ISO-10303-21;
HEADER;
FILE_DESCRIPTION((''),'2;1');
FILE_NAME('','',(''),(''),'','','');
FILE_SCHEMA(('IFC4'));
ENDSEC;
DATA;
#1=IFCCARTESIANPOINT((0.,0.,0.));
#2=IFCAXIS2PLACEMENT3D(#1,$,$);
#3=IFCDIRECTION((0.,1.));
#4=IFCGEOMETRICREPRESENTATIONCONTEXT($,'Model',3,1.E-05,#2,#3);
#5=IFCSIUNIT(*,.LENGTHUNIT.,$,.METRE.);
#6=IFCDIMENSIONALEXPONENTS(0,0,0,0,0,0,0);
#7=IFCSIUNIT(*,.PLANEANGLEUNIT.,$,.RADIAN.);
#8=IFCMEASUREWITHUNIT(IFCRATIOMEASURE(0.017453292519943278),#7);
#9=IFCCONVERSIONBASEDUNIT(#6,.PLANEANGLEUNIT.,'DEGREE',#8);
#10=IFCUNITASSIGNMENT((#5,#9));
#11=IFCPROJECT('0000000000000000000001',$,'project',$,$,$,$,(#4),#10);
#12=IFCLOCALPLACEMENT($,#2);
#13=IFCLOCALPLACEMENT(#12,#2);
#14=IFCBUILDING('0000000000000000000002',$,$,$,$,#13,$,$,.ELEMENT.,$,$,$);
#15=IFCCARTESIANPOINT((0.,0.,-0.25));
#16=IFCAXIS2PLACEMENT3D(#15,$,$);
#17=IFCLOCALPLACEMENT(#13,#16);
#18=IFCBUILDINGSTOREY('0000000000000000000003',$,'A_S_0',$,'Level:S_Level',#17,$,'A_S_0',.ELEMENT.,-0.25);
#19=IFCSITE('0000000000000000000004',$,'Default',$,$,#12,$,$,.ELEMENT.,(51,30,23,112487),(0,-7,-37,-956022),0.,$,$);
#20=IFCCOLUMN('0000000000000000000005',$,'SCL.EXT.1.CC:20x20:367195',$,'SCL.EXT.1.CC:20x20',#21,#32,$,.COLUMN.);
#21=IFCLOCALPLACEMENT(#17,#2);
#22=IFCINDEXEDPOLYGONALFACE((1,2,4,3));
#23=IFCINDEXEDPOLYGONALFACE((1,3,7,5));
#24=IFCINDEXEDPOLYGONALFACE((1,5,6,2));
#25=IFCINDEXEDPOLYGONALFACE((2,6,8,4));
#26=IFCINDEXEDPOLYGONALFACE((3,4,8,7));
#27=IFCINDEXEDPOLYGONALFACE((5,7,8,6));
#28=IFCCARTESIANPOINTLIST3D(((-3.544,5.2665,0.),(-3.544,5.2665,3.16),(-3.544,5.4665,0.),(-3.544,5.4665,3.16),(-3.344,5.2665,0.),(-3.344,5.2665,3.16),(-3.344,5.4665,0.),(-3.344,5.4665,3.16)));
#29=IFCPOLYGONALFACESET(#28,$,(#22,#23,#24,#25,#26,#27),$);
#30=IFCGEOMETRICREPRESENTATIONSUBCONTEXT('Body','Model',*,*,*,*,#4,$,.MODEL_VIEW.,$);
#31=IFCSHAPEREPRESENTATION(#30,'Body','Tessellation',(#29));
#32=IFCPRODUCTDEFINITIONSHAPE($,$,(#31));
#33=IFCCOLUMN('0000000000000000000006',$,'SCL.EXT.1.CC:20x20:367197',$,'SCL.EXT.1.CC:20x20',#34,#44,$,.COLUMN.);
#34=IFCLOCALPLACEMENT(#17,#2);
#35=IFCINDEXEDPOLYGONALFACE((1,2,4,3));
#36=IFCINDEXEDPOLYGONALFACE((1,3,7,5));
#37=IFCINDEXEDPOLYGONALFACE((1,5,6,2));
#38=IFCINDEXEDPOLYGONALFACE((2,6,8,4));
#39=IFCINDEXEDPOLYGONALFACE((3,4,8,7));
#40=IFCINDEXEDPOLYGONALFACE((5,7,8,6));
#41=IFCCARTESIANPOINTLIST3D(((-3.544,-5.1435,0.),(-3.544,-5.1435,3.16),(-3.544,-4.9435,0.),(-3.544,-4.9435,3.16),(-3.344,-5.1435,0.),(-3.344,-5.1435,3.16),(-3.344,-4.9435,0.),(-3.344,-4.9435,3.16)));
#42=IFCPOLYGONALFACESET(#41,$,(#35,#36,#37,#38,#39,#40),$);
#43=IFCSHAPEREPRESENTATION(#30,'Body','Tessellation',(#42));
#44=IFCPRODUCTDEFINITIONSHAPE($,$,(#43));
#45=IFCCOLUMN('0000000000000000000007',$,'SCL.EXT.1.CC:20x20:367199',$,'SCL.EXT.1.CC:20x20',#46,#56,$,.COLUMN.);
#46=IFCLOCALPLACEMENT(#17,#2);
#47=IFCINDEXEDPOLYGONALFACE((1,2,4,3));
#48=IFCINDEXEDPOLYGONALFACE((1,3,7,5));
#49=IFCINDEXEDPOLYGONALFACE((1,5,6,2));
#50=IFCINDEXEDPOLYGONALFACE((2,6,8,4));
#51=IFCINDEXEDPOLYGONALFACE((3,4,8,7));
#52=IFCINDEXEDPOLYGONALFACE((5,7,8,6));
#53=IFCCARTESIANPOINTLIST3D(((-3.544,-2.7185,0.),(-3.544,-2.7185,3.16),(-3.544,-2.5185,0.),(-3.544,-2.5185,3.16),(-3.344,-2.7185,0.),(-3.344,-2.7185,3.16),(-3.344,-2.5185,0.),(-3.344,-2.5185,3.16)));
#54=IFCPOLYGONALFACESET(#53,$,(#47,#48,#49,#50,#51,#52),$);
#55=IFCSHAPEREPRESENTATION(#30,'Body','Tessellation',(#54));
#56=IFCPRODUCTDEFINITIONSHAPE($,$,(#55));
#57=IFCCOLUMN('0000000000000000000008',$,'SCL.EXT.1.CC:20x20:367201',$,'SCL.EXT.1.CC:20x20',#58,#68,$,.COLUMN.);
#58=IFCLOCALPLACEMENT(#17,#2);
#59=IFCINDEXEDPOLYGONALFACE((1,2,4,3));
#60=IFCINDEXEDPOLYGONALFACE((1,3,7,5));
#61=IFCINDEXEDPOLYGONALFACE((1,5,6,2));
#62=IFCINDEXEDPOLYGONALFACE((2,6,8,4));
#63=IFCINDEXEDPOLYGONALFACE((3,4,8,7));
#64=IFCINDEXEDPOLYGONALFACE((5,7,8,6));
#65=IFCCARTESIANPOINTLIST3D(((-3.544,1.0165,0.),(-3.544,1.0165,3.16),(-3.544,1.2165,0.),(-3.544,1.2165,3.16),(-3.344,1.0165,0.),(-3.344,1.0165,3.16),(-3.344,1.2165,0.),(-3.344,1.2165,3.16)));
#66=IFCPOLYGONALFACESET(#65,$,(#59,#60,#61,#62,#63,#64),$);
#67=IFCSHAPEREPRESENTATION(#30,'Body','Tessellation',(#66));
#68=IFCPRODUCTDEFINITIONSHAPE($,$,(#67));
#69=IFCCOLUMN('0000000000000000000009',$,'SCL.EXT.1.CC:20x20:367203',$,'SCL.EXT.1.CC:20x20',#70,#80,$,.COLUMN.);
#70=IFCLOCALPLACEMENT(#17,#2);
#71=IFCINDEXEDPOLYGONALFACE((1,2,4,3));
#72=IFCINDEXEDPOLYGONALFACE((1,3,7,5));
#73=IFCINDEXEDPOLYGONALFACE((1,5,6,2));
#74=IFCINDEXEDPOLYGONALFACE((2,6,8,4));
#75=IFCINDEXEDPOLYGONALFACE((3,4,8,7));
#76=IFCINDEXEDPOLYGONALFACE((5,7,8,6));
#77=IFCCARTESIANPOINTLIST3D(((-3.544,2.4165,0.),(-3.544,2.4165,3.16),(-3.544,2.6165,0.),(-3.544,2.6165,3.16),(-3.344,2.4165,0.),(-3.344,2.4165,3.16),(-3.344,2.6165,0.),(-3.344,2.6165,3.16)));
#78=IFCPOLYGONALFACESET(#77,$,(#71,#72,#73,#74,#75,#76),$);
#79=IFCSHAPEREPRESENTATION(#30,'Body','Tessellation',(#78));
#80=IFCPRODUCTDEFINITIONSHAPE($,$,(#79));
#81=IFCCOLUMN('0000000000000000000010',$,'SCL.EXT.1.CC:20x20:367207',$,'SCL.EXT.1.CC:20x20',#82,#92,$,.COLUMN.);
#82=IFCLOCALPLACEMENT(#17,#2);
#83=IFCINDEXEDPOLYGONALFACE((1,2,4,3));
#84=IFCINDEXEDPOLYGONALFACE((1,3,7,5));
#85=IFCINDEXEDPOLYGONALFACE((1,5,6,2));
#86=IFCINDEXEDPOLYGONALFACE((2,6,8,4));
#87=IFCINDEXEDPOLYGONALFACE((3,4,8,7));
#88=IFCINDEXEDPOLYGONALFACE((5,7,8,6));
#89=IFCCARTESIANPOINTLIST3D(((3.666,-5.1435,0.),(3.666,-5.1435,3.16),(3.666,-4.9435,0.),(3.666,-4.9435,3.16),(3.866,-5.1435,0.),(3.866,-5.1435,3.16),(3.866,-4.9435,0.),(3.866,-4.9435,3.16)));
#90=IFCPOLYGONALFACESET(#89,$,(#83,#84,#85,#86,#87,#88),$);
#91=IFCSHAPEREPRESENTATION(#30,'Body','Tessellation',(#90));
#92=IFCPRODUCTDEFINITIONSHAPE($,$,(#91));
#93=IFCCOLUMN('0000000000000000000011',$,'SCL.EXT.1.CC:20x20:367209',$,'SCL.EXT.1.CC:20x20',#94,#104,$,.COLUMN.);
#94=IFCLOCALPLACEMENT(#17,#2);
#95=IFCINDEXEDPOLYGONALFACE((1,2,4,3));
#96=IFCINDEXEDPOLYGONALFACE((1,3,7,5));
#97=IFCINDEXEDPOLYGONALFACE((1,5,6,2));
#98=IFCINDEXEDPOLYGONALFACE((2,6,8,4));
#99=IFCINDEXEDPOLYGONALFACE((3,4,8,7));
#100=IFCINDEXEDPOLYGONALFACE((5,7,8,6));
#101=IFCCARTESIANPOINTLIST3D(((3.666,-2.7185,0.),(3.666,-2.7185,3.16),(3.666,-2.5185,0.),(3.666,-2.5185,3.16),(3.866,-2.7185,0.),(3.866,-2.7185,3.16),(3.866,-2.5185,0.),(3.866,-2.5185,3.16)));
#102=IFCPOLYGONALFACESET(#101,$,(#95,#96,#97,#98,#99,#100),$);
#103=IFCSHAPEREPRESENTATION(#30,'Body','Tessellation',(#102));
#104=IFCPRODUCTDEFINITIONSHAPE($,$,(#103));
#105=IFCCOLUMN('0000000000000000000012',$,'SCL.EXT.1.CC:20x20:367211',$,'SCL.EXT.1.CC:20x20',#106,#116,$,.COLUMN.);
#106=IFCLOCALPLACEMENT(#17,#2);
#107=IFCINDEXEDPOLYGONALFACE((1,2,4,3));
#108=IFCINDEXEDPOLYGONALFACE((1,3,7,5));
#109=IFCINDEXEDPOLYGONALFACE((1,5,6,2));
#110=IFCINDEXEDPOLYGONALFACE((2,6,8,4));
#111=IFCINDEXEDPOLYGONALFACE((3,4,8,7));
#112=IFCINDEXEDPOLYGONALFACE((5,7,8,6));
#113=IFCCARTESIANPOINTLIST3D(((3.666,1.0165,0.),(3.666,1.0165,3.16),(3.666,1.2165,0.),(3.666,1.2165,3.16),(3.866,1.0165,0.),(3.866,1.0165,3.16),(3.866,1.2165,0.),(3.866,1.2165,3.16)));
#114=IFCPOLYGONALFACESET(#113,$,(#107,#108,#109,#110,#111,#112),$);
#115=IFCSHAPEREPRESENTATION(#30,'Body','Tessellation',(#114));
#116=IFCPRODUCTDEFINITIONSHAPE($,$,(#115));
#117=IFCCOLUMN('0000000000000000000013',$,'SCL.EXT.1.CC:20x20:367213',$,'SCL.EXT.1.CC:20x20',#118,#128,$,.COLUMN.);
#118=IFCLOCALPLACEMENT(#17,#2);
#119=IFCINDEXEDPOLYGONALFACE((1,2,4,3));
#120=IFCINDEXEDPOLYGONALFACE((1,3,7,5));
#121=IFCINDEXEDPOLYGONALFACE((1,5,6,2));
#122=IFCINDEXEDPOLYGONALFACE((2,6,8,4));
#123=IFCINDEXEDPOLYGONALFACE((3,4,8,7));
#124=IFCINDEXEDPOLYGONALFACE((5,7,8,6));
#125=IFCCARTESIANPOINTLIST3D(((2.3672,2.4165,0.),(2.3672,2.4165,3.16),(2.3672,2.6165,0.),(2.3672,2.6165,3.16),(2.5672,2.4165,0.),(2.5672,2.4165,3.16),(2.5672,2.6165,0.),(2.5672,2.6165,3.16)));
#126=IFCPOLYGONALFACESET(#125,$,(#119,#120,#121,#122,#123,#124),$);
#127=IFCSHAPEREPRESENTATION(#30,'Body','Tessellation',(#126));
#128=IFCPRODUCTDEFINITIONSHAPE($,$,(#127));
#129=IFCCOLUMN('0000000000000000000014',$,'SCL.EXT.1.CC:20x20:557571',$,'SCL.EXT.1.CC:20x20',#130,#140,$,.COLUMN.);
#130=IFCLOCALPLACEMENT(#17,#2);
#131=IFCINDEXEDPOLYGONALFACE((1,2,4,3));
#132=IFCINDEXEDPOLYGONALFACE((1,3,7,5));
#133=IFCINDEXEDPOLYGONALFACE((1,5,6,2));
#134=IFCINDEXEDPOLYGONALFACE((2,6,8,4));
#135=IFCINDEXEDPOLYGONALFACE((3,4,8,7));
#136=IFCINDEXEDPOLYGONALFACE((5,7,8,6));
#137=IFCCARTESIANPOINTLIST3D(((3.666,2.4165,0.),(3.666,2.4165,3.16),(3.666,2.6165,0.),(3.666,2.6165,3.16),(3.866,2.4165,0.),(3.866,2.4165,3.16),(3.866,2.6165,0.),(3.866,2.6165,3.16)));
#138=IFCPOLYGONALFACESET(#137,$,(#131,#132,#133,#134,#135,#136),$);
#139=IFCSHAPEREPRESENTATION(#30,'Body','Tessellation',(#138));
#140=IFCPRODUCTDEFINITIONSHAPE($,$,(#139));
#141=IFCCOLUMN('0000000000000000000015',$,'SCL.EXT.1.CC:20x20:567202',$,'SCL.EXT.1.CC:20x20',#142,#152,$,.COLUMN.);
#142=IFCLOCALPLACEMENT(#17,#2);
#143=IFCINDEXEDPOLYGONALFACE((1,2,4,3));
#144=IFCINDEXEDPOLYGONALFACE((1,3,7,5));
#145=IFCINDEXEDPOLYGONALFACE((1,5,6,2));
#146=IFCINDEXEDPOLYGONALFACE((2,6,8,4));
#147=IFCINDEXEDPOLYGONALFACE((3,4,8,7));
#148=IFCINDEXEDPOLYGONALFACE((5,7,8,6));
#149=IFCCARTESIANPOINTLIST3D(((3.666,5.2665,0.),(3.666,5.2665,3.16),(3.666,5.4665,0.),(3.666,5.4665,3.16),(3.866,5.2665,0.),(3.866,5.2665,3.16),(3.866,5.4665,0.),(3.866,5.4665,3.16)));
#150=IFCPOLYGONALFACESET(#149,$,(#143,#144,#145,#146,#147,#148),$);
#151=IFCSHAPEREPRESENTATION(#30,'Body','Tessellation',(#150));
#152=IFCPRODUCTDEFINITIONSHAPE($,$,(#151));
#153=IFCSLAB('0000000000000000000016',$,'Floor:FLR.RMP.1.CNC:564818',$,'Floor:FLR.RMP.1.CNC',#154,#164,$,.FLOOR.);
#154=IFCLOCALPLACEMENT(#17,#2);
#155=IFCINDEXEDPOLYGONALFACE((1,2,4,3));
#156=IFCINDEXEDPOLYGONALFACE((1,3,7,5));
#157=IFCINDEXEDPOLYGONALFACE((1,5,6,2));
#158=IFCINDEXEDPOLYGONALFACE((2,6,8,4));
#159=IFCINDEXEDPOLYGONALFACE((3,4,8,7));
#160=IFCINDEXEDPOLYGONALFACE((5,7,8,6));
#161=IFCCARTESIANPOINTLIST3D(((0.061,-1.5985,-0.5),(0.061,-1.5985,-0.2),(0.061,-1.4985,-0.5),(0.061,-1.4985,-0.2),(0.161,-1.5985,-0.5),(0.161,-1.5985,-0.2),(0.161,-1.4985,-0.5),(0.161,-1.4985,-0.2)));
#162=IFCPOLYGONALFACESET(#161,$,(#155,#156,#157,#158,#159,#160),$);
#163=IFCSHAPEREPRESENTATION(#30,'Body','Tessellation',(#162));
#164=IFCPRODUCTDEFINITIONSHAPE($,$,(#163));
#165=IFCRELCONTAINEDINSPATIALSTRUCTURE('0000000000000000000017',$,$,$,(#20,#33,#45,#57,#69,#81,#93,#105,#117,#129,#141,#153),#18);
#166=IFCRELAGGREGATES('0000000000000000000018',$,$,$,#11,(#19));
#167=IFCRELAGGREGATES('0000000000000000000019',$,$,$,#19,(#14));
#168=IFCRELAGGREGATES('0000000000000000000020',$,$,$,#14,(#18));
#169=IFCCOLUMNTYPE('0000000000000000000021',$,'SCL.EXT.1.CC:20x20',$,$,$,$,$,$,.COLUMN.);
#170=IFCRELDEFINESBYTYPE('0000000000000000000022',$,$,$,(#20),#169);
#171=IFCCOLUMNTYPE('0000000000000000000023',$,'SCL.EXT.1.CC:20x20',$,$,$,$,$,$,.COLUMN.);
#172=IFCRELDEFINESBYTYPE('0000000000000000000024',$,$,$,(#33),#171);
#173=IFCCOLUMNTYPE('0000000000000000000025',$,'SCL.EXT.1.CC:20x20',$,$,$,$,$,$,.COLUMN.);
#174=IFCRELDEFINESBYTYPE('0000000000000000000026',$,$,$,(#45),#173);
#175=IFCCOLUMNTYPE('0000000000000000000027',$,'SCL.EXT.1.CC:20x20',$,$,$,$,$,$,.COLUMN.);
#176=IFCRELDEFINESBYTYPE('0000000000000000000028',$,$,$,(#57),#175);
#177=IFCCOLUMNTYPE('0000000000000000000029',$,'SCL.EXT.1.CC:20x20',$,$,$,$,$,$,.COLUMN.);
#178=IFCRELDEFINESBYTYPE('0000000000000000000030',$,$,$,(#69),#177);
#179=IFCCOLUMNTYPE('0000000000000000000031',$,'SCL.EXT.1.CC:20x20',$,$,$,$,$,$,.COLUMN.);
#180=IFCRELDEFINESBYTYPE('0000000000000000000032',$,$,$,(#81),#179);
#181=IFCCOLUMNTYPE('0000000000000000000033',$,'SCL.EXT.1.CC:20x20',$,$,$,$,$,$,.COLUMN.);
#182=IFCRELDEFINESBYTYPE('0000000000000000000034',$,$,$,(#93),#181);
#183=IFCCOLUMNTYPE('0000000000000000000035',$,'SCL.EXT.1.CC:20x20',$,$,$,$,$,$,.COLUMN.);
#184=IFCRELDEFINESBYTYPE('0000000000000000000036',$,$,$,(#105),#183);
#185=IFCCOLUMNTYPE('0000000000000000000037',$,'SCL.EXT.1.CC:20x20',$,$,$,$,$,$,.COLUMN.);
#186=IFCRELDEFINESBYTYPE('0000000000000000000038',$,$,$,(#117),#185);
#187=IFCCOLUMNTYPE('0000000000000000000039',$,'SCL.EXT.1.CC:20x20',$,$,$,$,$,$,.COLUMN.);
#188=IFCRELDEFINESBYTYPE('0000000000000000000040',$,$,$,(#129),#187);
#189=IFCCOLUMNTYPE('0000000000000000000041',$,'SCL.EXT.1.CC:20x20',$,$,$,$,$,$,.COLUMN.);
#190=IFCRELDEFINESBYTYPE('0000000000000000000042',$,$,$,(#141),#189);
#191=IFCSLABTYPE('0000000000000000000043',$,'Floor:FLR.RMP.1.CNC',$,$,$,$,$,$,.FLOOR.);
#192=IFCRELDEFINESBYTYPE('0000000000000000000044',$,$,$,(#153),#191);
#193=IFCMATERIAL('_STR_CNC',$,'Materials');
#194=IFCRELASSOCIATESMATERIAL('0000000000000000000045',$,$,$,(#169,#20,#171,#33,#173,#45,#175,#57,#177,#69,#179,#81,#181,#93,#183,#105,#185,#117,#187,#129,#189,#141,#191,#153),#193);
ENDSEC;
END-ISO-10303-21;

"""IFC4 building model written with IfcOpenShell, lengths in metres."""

from ifc_helpers import new_model, entity, si_unit, converted_unit, direction, frame, origin, place, context, subcontext, project, spatial, indexed_curve, outline, extrude, source, transform, mapped, material, type_object, type_shapes, element, save


model = new_model("IFC4")

# Units and contexts
model_context = context("Model", 3, precision=1e-05, world=origin(), true_north=direction((0.0, 1.0)))
body_context = subcontext(model_context, "Body", "Model", "MODEL_VIEW")
ifc_project = project(units=[si_unit("LENGTHUNIT", "METRE"), converted_unit("PLANEANGLEUNIT", "DEGREE", entity("IfcRatioMeasure", 0.017453292519943278), si_unit("PLANEANGLEUNIT", "RADIAN"), dimensions=[0, 0, 0, 0, 0, 0, 0])], contexts=[model_context])

# Site, building, storey
site_placement = place(None, origin())
site = spatial("IfcSite", under=ifc_project, at=site_placement, Name="Default", CompositionType="ELEMENT", RefLatitude=(51, 30, 23, 112487), RefLongitude=(0, -7, -37, -956022), RefElevation=0.0)
building_placement = place(site_placement, origin())
building = spatial("IfcBuilding", under=site, at=building_placement, CompositionType="ELEMENT")
storey_placement = place(building_placement, frame((0.0, 0.0, -0.25)))
storey = spatial("IfcBuildingStorey", under=building, at=storey_placement, Name="A_S_0", ObjectType="Level:S_Level", LongName="A_S_0", CompositionType="ELEMENT", Elevation=-0.25)

# Columns
ifc_material_1 = material(Name="_STR_CNC", Category="Materials")
column_type_1 = type_object("IfcColumnType", Name="SCL.EXT.1.CC:20x20", PredefinedType="COLUMN", material=ifc_material_1)
shared_shape_1 = source(origin(), body_context, "Body", "SweptSolid", [
    extrude(outline(indexed_curve([(-0.1, -0.1), (0.1, -0.1), (0.1, 0.1), (-0.1, 0.1), (-0.1, -0.1)], self_intersect=False)), frame((-3.444, 5.3665, -0.25), z_axis=(0.0, 0.0, 1.0), x_axis=(0.0, -1.0, 0.0)), (0.0, 0.0, 1.0), 3.16),
])
type_shapes(column_type_1, [shared_shape_1])
column_1_placement = place(storey_placement, frame((0.0, 0.0, 0.25)))
element("IfcColumn", 1, at=column_1_placement, inside=storey, type_object=column_type_1, material=ifc_material_1, Name="SCL.EXT.1.CC:20x20:367195", ObjectType="SCL.EXT.1.CC:20x20", PredefinedType="COLUMN", context=body_context, shape_type="MappedRepresentation", body=[
    mapped(shared_shape_1, transform((0.0, 0.0, 0.0), scale=1.0)),
])
column_type_2 = type_object("IfcColumnType", Name="SCL.EXT.1.CC:20x20", PredefinedType="COLUMN", material=ifc_material_1)
shared_shape_2 = source(origin(), body_context, "Body", "SweptSolid", [
    extrude(outline(indexed_curve([(-0.1, -0.1), (0.1, -0.1), (0.1, 0.1), (-0.1, 0.1), (-0.1, -0.1)], self_intersect=False)), frame((-3.444, -5.0435, -0.25), z_axis=(0.0, 0.0, 1.0), x_axis=(0.0, -1.0, 0.0)), (0.0, 0.0, 1.0), 3.16),
])
type_shapes(column_type_2, [shared_shape_2])
column_2_placement = place(storey_placement, frame((0.0, 0.0, 0.25)))
element("IfcColumn", 2, at=column_2_placement, inside=storey, type_object=column_type_2, material=ifc_material_1, Name="SCL.EXT.1.CC:20x20:367197", ObjectType="SCL.EXT.1.CC:20x20", PredefinedType="COLUMN", context=body_context, shape_type="MappedRepresentation", body=[
    mapped(shared_shape_2, transform((0.0, 0.0, 0.0), scale=1.0)),
])
column_type_3 = type_object("IfcColumnType", Name="SCL.EXT.1.CC:20x20", PredefinedType="COLUMN", material=ifc_material_1)
shared_shape_3 = source(origin(), body_context, "Body", "SweptSolid", [
    extrude(outline(indexed_curve([(-0.1, -0.1), (0.1, -0.1), (0.1, 0.1), (-0.1, 0.1), (-0.1, -0.1)], self_intersect=False)), frame((-3.444, -2.6185, -0.25), z_axis=(0.0, 0.0, 1.0), x_axis=(0.0, -1.0, 0.0)), (0.0, 0.0, 1.0), 3.16),
])
type_shapes(column_type_3, [shared_shape_3])
column_3_placement = place(storey_placement, frame((0.0, 0.0, 0.25)))
element("IfcColumn", 3, at=column_3_placement, inside=storey, type_object=column_type_3, material=ifc_material_1, Name="SCL.EXT.1.CC:20x20:367199", ObjectType="SCL.EXT.1.CC:20x20", PredefinedType="COLUMN", context=body_context, shape_type="MappedRepresentation", body=[
    mapped(shared_shape_3, transform((0.0, 0.0, 0.0), scale=1.0)),
])
column_type_4 = type_object("IfcColumnType", Name="SCL.EXT.1.CC:20x20", PredefinedType="COLUMN", material=ifc_material_1)
shared_shape_4 = source(origin(), body_context, "Body", "SweptSolid", [
    extrude(outline(indexed_curve([(-0.1, -0.1), (0.1, -0.1), (0.1, 0.1), (-0.1, 0.1), (-0.1, -0.1)], self_intersect=False)), frame((-3.444, 1.1165, -0.25), z_axis=(0.0, 0.0, 1.0), x_axis=(0.0, -1.0, 0.0)), (0.0, 0.0, 1.0), 3.16),
])
type_shapes(column_type_4, [shared_shape_4])
column_4_placement = place(storey_placement, frame((0.0, 0.0, 0.25)))
element("IfcColumn", 4, at=column_4_placement, inside=storey, type_object=column_type_4, material=ifc_material_1, Name="SCL.EXT.1.CC:20x20:367201", ObjectType="SCL.EXT.1.CC:20x20", PredefinedType="COLUMN", context=body_context, shape_type="MappedRepresentation", body=[
    mapped(shared_shape_4, transform((0.0, 0.0, 0.0), scale=1.0)),
])
column_type_5 = type_object("IfcColumnType", Name="SCL.EXT.1.CC:20x20", PredefinedType="COLUMN", material=ifc_material_1)
shared_shape_5 = source(origin(), body_context, "Body", "SweptSolid", [
    extrude(outline(indexed_curve([(-0.1, -0.1), (0.1, -0.1), (0.1, 0.1), (-0.1, 0.1), (-0.1, -0.1)], self_intersect=False)), frame((-3.444, 2.5165, -0.25), z_axis=(0.0, 0.0, 1.0), x_axis=(0.0, -1.0, 0.0)), (0.0, 0.0, 1.0), 3.16),
])
type_shapes(column_type_5, [shared_shape_5])
column_5_placement = place(storey_placement, frame((0.0, 0.0, 0.25)))
element("IfcColumn", 5, at=column_5_placement, inside=storey, type_object=column_type_5, material=ifc_material_1, Name="SCL.EXT.1.CC:20x20:367203", ObjectType="SCL.EXT.1.CC:20x20", PredefinedType="COLUMN", context=body_context, shape_type="MappedRepresentation", body=[
    mapped(shared_shape_5, transform((0.0, 0.0, 0.0), scale=1.0)),
])
column_type_6 = type_object("IfcColumnType", Name="SCL.EXT.1.CC:20x20", PredefinedType="COLUMN", material=ifc_material_1)
shared_shape_6 = source(origin(), body_context, "Body", "SweptSolid", [
    extrude(outline(indexed_curve([(-0.1, -0.1), (0.1, -0.1), (0.1, 0.1), (-0.1, 0.1), (-0.1, -0.1)], self_intersect=False)), frame((3.766, -5.0435, -0.25), z_axis=(0.0, 0.0, 1.0), x_axis=(0.0, -1.0, 0.0)), (0.0, 0.0, 1.0), 3.16),
])
type_shapes(column_type_6, [shared_shape_6])
column_6_placement = place(storey_placement, frame((0.0, 0.0, 0.25)))
element("IfcColumn", 6, at=column_6_placement, inside=storey, type_object=column_type_6, material=ifc_material_1, Name="SCL.EXT.1.CC:20x20:367207", ObjectType="SCL.EXT.1.CC:20x20", PredefinedType="COLUMN", context=body_context, shape_type="MappedRepresentation", body=[
    mapped(shared_shape_6, transform((0.0, 0.0, 0.0), scale=1.0)),
])
column_type_7 = type_object("IfcColumnType", Name="SCL.EXT.1.CC:20x20", PredefinedType="COLUMN", material=ifc_material_1)
shared_shape_7 = source(origin(), body_context, "Body", "SweptSolid", [
    extrude(outline(indexed_curve([(-0.1, -0.1), (0.1, -0.1), (0.1, 0.1), (-0.1, 0.1), (-0.1, -0.1)], self_intersect=False)), frame((3.766, -2.6185, -0.25), z_axis=(0.0, 0.0, 1.0), x_axis=(0.0, -1.0, 0.0)), (0.0, 0.0, 1.0), 3.16),
])
type_shapes(column_type_7, [shared_shape_7])
column_7_placement = place(storey_placement, frame((0.0, 0.0, 0.25)))
element("IfcColumn", 7, at=column_7_placement, inside=storey, type_object=column_type_7, material=ifc_material_1, Name="SCL.EXT.1.CC:20x20:367209", ObjectType="SCL.EXT.1.CC:20x20", PredefinedType="COLUMN", context=body_context, shape_type="MappedRepresentation", body=[
    mapped(shared_shape_7, transform((0.0, 0.0, 0.0), scale=1.0)),
])
column_type_8 = type_object("IfcColumnType", Name="SCL.EXT.1.CC:20x20", PredefinedType="COLUMN", material=ifc_material_1)
shared_shape_8 = source(origin(), body_context, "Body", "SweptSolid", [
    extrude(outline(indexed_curve([(-0.1, -0.1), (0.1, -0.1), (0.1, 0.1), (-0.1, 0.1), (-0.1, -0.1)], self_intersect=False)), frame((3.766, 1.1165, -0.25), z_axis=(0.0, 0.0, 1.0), x_axis=(0.0, -1.0, 0.0)), (0.0, 0.0, 1.0), 3.16),
])
type_shapes(column_type_8, [shared_shape_8])
column_8_placement = place(storey_placement, frame((0.0, 0.0, 0.25)))
element("IfcColumn", 8, at=column_8_placement, inside=storey, type_object=column_type_8, material=ifc_material_1, Name="SCL.EXT.1.CC:20x20:367211", ObjectType="SCL.EXT.1.CC:20x20", PredefinedType="COLUMN", context=body_context, shape_type="MappedRepresentation", body=[
    mapped(shared_shape_8, transform((0.0, 0.0, 0.0), scale=1.0)),
])
column_type_9 = type_object("IfcColumnType", Name="SCL.EXT.1.CC:20x20", PredefinedType="COLUMN", material=ifc_material_1)
shared_shape_9 = source(origin(), body_context, "Body", "SweptSolid", [
    extrude(outline(indexed_curve([(-0.1, -0.1), (0.1, -0.1), (0.1, 0.1), (-0.1, 0.1), (-0.1, -0.1)], self_intersect=False)), frame((2.4672, 2.5165, -0.25), z_axis=(0.0, 0.0, 1.0), x_axis=(0.0, -1.0, 0.0)), (0.0, 0.0, 1.0), 3.16),
])
type_shapes(column_type_9, [shared_shape_9])
column_9_placement = place(storey_placement, frame((0.0, 0.0, 0.25)))
element("IfcColumn", 9, at=column_9_placement, inside=storey, type_object=column_type_9, material=ifc_material_1, Name="SCL.EXT.1.CC:20x20:367213", ObjectType="SCL.EXT.1.CC:20x20", PredefinedType="COLUMN", context=body_context, shape_type="MappedRepresentation", body=[
    mapped(shared_shape_9, transform((0.0, 0.0, 0.0), scale=1.0)),
])
column_type_10 = type_object("IfcColumnType", Name="SCL.EXT.1.CC:20x20", PredefinedType="COLUMN", material=ifc_material_1)
shared_shape_10 = source(origin(), body_context, "Body", "SweptSolid", [
    extrude(outline(indexed_curve([(-0.1, -0.1), (0.1, -0.1), (0.1, 0.1), (-0.1, 0.1), (-0.1, -0.1)], self_intersect=False)), frame((3.766, 2.5165, -0.25), z_axis=(0.0, 0.0, 1.0), x_axis=(0.0, -1.0, 0.0)), (0.0, 0.0, 1.0), 3.16),
])
type_shapes(column_type_10, [shared_shape_10])
column_10_placement = place(storey_placement, frame((0.0, 0.0, 0.25)))
element("IfcColumn", 10, at=column_10_placement, inside=storey, type_object=column_type_10, material=ifc_material_1, Name="SCL.EXT.1.CC:20x20:557571", ObjectType="SCL.EXT.1.CC:20x20", PredefinedType="COLUMN", context=body_context, shape_type="MappedRepresentation", body=[
    mapped(shared_shape_10, transform((0.0, 0.0, 0.0), scale=1.0)),
])
column_type_11 = type_object("IfcColumnType", Name="SCL.EXT.1.CC:20x20", PredefinedType="COLUMN", material=ifc_material_1)
shared_shape_11 = source(origin(), body_context, "Body", "SweptSolid", [
    extrude(outline(indexed_curve([(-0.1, -0.1), (0.1, -0.1), (0.1, 0.1), (-0.1, 0.1), (-0.1, -0.1)], self_intersect=False)), frame((3.766, 5.3665, -0.25), z_axis=(0.0, 0.0, 1.0), x_axis=(0.0, -1.0, 0.0)), (0.0, 0.0, 1.0), 3.16),
])
type_shapes(column_type_11, [shared_shape_11])
column_11_placement = place(storey_placement, frame((0.0, 0.0, 0.25)))
element("IfcColumn", 11, at=column_11_placement, inside=storey, type_object=column_type_11, material=ifc_material_1, Name="SCL.EXT.1.CC:20x20:567202", ObjectType="SCL.EXT.1.CC:20x20", PredefinedType="COLUMN", context=body_context, shape_type="MappedRepresentation", body=[
    mapped(shared_shape_11, transform((0.0, 0.0, 0.0), scale=1.0)),
])

# Slab
slab_type = type_object("IfcSlabType", Name="Floor:FLR.RMP.1.CNC", PredefinedType="FLOOR", material=ifc_material_1)
slab_placement = place(storey_placement, origin())
element("IfcSlab", 12, at=slab_placement, inside=storey, type_object=slab_type, material=ifc_material_1, Name="Floor:FLR.RMP.1.CNC:564818", ObjectType="Floor:FLR.RMP.1.CNC", PredefinedType="FLOOR", context=body_context, shape_type="SweptSolid", body=[
    extrude(outline(indexed_curve([(-0.05, -0.05), (0.05, -0.05), (0.05, 0.05), (-0.05, 0.05), (-0.05, -0.05)], self_intersect=False)), frame((0.111, -1.5485, -0.2), z_axis=(0.0, 0.0, -1.0), x_axis=(0.0, 1.0, 0.0)), (0.0, 0.0, 1.0), 0.3),
])

save(model, "model.ifc")
